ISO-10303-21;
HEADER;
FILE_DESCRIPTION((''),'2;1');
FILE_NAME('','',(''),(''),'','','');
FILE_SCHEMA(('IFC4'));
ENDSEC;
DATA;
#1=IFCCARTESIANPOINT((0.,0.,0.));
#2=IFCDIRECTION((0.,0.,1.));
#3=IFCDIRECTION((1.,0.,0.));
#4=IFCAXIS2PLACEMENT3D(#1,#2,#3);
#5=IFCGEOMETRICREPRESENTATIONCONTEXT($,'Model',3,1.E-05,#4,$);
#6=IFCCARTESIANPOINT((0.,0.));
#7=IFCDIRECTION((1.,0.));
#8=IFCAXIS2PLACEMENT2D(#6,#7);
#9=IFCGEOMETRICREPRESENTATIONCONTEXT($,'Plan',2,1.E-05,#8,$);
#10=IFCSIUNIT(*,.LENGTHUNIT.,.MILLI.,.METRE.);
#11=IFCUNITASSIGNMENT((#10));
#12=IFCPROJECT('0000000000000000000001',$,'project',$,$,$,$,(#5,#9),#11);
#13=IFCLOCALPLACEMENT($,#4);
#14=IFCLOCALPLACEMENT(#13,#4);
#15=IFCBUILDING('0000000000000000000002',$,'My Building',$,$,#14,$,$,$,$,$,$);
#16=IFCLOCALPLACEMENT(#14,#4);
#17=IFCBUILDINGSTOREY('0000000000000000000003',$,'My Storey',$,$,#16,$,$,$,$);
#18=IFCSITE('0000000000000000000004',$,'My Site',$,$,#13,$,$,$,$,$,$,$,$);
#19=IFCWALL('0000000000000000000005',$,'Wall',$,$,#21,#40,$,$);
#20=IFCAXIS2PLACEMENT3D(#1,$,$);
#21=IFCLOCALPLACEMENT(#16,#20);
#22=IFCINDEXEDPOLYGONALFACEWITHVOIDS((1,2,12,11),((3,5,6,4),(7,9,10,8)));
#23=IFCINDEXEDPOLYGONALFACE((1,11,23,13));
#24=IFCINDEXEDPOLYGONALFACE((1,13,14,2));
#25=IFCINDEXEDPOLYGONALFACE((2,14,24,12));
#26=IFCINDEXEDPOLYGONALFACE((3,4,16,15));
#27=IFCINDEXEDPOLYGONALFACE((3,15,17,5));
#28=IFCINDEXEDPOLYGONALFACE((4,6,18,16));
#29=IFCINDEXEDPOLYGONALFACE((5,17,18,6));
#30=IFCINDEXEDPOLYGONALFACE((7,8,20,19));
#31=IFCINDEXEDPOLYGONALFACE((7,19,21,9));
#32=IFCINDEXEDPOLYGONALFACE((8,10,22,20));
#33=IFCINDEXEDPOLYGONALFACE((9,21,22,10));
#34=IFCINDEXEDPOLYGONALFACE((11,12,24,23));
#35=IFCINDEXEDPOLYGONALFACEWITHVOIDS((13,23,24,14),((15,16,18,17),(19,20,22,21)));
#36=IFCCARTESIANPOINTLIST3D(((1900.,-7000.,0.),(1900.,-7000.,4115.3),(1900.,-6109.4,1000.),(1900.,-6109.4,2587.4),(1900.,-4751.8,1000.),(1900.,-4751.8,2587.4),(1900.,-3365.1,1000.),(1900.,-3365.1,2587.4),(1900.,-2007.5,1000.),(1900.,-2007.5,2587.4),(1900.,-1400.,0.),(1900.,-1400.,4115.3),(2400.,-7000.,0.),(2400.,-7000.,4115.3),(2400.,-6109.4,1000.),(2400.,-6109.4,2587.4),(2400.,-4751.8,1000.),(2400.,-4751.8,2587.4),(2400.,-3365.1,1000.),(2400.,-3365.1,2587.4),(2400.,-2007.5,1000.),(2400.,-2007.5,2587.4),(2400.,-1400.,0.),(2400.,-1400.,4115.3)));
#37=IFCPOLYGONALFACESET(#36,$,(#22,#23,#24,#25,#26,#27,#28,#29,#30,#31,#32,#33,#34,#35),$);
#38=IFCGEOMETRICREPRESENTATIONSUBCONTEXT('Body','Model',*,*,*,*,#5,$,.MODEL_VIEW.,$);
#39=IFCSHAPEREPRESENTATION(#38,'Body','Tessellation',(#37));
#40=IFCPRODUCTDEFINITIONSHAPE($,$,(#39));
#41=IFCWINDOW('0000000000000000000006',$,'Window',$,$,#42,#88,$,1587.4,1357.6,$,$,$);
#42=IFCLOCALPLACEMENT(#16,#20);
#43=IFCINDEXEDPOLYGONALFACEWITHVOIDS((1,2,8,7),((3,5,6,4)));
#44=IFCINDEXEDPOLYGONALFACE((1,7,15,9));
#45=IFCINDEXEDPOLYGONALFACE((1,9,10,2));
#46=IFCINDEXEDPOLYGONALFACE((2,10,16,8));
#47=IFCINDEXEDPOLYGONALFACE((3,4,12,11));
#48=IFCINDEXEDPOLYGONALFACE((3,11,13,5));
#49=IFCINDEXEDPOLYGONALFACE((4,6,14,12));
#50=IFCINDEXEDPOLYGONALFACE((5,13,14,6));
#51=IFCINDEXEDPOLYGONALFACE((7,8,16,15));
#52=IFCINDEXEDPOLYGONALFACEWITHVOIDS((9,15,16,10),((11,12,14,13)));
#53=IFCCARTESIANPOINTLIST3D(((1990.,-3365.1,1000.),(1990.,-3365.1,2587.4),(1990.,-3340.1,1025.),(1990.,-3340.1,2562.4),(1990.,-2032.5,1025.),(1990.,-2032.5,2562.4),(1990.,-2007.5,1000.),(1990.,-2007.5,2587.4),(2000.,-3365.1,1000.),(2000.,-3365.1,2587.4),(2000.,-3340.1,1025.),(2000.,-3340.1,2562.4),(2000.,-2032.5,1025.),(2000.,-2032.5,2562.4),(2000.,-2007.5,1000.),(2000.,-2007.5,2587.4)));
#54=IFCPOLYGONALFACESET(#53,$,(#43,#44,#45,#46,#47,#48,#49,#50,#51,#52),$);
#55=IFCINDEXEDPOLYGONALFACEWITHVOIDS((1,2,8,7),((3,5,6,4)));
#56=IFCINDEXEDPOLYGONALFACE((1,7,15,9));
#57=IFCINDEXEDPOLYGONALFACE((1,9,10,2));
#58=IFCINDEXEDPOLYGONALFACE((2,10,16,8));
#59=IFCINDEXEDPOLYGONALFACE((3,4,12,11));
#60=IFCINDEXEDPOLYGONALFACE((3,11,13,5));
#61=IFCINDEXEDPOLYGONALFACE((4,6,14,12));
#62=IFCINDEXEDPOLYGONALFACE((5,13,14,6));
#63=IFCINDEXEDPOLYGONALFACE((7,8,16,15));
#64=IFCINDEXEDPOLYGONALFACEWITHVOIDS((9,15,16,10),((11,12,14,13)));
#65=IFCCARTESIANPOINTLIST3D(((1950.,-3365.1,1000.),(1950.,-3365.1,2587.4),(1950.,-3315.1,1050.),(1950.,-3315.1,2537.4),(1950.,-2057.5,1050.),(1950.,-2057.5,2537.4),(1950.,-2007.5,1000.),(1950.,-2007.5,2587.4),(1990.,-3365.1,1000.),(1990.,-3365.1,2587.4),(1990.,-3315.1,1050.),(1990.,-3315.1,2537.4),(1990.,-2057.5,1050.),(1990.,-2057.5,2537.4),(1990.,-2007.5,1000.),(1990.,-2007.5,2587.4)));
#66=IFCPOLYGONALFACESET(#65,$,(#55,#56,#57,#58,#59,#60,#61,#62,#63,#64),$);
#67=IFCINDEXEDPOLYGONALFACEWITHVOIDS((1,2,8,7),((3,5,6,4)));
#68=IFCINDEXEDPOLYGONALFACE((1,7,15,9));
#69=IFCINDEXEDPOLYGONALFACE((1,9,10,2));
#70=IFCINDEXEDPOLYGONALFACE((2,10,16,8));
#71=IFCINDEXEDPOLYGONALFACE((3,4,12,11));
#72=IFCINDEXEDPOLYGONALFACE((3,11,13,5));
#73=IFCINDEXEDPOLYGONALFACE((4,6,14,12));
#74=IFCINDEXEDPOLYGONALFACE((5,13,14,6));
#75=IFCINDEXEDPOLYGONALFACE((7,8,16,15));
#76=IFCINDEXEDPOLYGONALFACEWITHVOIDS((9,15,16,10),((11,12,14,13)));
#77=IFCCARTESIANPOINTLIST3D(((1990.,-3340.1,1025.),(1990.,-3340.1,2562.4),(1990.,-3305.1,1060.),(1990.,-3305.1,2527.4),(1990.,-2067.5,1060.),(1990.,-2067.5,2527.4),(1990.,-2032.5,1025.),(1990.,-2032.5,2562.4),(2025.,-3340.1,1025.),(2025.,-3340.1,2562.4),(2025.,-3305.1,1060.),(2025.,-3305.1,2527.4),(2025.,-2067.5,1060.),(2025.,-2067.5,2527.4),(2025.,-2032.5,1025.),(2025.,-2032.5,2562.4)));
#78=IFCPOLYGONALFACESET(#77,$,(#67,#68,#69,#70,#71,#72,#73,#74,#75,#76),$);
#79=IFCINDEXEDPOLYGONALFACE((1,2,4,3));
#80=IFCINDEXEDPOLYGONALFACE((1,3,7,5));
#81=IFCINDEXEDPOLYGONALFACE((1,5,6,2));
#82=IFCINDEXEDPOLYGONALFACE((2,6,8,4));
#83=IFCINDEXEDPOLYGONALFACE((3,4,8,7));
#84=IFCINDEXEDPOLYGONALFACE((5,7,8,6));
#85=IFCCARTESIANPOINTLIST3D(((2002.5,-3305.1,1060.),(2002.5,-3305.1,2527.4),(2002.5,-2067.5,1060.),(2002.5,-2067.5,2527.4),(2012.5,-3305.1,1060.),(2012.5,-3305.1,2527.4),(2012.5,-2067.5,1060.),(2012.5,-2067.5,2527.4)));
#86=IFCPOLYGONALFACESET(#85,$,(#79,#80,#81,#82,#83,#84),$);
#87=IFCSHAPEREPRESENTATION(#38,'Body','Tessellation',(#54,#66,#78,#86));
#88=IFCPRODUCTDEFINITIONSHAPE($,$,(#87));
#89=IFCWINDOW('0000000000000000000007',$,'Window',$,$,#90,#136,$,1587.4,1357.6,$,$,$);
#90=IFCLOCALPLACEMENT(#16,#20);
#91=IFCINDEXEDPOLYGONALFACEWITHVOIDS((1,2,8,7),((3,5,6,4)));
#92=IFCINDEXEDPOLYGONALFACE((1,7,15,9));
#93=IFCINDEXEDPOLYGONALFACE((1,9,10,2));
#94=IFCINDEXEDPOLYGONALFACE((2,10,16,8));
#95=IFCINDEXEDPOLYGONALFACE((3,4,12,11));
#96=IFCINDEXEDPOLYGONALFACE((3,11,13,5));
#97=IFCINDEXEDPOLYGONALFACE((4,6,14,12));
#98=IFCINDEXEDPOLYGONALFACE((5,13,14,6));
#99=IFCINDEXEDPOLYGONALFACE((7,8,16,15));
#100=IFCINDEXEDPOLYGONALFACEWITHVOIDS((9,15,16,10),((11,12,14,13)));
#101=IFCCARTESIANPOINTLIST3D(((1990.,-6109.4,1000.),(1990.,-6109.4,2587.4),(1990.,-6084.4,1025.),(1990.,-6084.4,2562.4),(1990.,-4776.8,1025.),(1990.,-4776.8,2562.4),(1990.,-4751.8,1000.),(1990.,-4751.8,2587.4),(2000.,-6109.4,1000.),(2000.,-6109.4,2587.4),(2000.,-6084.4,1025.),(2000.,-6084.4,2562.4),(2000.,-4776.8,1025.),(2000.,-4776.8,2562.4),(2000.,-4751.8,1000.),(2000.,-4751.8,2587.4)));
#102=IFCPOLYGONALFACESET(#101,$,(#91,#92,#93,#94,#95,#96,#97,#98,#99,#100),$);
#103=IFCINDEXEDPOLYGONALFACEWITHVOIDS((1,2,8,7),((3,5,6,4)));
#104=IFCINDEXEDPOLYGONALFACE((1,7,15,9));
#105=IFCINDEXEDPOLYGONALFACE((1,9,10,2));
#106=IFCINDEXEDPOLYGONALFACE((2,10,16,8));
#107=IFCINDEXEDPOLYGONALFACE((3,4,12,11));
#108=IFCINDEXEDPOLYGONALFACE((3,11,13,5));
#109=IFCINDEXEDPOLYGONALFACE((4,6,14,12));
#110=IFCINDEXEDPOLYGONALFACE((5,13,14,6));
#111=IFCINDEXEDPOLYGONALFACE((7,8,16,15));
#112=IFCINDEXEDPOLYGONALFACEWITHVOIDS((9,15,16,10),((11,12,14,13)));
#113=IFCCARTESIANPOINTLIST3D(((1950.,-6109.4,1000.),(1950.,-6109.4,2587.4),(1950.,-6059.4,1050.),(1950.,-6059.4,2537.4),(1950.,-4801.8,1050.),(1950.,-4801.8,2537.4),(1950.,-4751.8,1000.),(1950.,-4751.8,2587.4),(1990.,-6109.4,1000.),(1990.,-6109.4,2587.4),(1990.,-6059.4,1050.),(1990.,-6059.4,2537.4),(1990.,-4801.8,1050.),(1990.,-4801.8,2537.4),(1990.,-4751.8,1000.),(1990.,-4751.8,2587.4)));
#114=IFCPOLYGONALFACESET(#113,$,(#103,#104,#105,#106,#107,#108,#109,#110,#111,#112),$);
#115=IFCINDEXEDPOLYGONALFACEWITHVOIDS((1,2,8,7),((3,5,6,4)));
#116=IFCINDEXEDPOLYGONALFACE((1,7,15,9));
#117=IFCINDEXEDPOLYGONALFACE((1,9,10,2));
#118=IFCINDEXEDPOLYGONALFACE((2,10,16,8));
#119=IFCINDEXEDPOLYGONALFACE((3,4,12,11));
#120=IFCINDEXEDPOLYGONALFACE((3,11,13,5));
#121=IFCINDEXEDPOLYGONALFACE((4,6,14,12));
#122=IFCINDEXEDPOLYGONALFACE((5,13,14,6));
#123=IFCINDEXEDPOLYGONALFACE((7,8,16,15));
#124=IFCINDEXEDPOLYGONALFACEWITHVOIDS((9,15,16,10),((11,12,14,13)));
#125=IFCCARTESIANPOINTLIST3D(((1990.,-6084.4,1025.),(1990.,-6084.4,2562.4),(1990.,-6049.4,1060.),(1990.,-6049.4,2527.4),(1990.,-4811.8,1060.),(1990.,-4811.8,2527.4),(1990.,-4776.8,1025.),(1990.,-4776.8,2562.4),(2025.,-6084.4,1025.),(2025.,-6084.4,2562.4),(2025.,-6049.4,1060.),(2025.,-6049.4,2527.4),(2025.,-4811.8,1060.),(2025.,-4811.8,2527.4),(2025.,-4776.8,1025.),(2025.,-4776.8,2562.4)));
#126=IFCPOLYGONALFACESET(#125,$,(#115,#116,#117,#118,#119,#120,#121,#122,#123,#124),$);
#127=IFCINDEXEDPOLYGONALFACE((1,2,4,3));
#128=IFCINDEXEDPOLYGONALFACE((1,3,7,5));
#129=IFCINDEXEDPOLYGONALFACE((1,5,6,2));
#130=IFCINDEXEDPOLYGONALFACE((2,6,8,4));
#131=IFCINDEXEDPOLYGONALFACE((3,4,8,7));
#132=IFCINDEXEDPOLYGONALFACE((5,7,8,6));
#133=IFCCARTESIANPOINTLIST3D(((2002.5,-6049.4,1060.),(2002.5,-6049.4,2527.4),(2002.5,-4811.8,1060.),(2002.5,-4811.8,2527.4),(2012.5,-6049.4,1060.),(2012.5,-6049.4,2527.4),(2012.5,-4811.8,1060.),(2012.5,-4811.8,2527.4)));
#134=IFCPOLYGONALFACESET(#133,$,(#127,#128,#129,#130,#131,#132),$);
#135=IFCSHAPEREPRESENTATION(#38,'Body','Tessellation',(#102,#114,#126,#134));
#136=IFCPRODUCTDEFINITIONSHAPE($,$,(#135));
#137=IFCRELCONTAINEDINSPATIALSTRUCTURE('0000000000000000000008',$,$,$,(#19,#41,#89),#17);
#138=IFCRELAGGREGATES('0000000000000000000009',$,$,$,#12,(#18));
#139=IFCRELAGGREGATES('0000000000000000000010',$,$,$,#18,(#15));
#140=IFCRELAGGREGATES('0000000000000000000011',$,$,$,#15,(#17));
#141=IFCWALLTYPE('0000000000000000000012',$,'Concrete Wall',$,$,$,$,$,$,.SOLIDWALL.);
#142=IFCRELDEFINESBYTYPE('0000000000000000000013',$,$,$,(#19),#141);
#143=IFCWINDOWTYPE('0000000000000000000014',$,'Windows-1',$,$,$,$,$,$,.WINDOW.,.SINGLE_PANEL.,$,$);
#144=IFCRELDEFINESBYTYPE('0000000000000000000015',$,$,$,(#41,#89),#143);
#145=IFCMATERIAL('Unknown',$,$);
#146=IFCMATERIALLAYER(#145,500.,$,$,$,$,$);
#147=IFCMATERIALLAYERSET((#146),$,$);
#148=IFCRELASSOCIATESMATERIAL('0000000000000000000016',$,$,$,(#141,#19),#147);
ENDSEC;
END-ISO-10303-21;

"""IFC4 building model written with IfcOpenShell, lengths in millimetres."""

from ifc_helpers import new_model, entity, si_unit, frame, origin_with_axes, origin_2d_with_axis, place, context, subcontext, project, spatial, line, indexed_curve, outline, extrude, shape, source, transform, mapped, material, layer, layer_set, layer_usage, type_object, type_shapes, element, fill, save


model = new_model("IFC4")

# Units and contexts
model_context = context("Model", 3, precision=1e-05, world=origin_with_axes())
plan_context = context("Plan", 2, precision=1e-05, world=origin_2d_with_axis())
body_context_1 = subcontext(model_context, "Body", "Model", "MODEL_VIEW")
body_context_2 = subcontext(plan_context, "Body", "Plan", "PLAN_VIEW")
ifc_project = project(units=[si_unit("LENGTHUNIT", "METRE", prefix="MILLI")], contexts=[model_context, plan_context])

# Site, building, storey
site_placement = place(None, origin_with_axes())
site = spatial("IfcSite", under=ifc_project, at=site_placement, Name="My Site")
building_placement = place(site_placement, origin_with_axes())
building = spatial("IfcBuilding", under=site, at=building_placement, Name="My Building")
storey_placement = place(building_placement, origin_with_axes())
storey = spatial("IfcBuildingStorey", under=building, at=storey_placement, Name="My Storey")

# Shared definitions
ifc_material = material(Name="Unknown")

# Wall, openings, windows
ifc_layer_1 = layer(ifc_material, 500.0)
ifc_layer_set_1 = layer_set([ifc_layer_1])
ifc_layer_usage_1 = layer_usage(ifc_layer_set_1, "AXIS2", "POSITIVE", 0.0)
wall_type = type_object("IfcWallType", Name="Concrete Wall", PredefinedType="SOLIDWALL", material=ifc_layer_set_1)
wall_1_placement = place(storey_placement, frame((1900.0, -1400.0, 0.0), z_axis=(0.0, 0.0, 1.0), x_axis=(0.0, -1.0, 0.0)))
wall_1 = element("IfcWall", 1, at=wall_1_placement, inside=storey, type_object=wall_type, material=ifc_layer_usage_1, Name="Wall", context=body_context_1, shape_type="SweptSolid", body=[
    extrude(outline(indexed_curve([(0.0, 0.0), (0.0, 500.0), (5600.0, 500.0), (5600.0, 0.0)], segments=[line(1, 2, 3, 4, 1)])), origin_with_axes(), (0.0, 0.0, 1.0), 4115.3),
])
shared_shape_1 = source(origin_with_axes(), body_context_1, "Body", "SweptSolid", [
    extrude(outline(indexed_curve([(0.0, 0.0), (1357.6, 0.0), (1357.6, 1587.4), (0.0, 1587.4)], segments=[line(1, 2, 3, 4, 1)])), frame((0.0, -600.0, 0.0), z_axis=(0.0, -1.0, 0.0), x_axis=(1.0, 0.0, 0.0)), (0.0, 0.0, -1.0), 1200.0),
])
opening_1_placement = place(wall_1_placement, frame((607.5, 0.0, 1000.0), z_axis=(0.0, 0.0, 1.0), x_axis=(1.0, 0.0, 0.0)))
opening_1 = element("IfcOpeningElement", 2, at=opening_1_placement, cuts=wall_1, PredefinedType="OPENING", context=body_context_1, shape_type="MappedRepresentation", body=[
    mapped(shared_shape_1, transform((0.0, 0.0, 0.0), x_axis=(1.0, 0.0, 0.0), y_axis=(0.0, 1.0, 0.0), z_axis=(0.0, 0.0, 1.0), scale=1.0)),
])
opening_2_placement = place(wall_1_placement, frame((3351.8, 0.0, 1000.0), z_axis=(0.0, 0.0, 1.0), x_axis=(1.0, 0.0, 0.0)))
opening_2 = element("IfcOpeningElement", 3, at=opening_2_placement, cuts=wall_1, PredefinedType="OPENING", context=body_context_1, shape_type="MappedRepresentation", body=[
    mapped(shared_shape_1, transform((0.0, 0.0, 0.0), x_axis=(1.0, 0.0, 0.0), y_axis=(0.0, 1.0, 0.0), z_axis=(0.0, 0.0, 1.0), scale=1.0)),
])
window_type = type_object("IfcWindowType", Name="Windows-1", PartitioningType="SINGLE_PANEL", PredefinedType="WINDOW")
shared_shape_2 = source(origin_with_axes(), body_context_1, "Body", "SweptSolid", [
    extrude(outline(indexed_curve([(0.0, 0.0), (1357.6, 0.0), (1357.6, 1587.4), (0.0, 1587.4)], segments=[line(1, 2, 3, 4, 1)]), holes=[indexed_curve([(25.0, 25.0), (1332.6, 25.0), (1332.6, 1562.4), (25.0, 1562.4)], segments=[line(1, 2, 3, 4, 1)])]), frame((0.0, 90.0, 0.0), z_axis=(0.0, -1.0, 0.0), x_axis=(1.0, 0.0, 0.0)), (0.0, 0.0, -1.0), 10.0),
    extrude(outline(indexed_curve([(0.0, 0.0), (1357.6, 0.0), (1357.6, 1587.4), (0.0, 1587.4)], segments=[line(1, 2, 3, 4, 1)]), holes=[indexed_curve([(50.0, 50.0), (1307.6, 50.0), (1307.6, 1537.4), (50.0, 1537.4)], segments=[line(1, 2, 3, 4, 1)])]), frame((0.0, 50.0, 0.0), z_axis=(0.0, -1.0, 0.0), x_axis=(1.0, 0.0, 0.0)), (0.0, 0.0, -1.0), 40.0),
    extrude(outline(indexed_curve([(0.0, 0.0), (1307.6, 0.0), (1307.6, 1537.4), (0.0, 1537.4)], segments=[line(1, 2, 3, 4, 1)]), holes=[indexed_curve([(35.0, 35.0), (1272.6, 35.0), (1272.6, 1502.4), (35.0, 1502.4)], segments=[line(1, 2, 3, 4, 1)])]), frame((25.0, 90.0, 25.0), z_axis=(0.0, -1.0, 0.0), x_axis=(1.0, 0.0, 0.0)), (0.0, 0.0, -1.0), 35.0),
    extrude(outline(indexed_curve([(35.0, 35.0), (1272.6, 35.0), (1272.6, 1502.4), (35.0, 1502.4)], segments=[line(1, 2, 3, 4, 1)])), frame((25.0, 102.5, 25.0), z_axis=(0.0, -1.0, 0.0), x_axis=(1.0, 0.0, 0.0)), (0.0, 0.0, -1.0), 10.0),
])
shared_shape_3 = source(origin_with_axes(), body_context_2, "Body", "Curve2D", [
    entity("IfcIndexedPolyCurve", entity("IfcCartesianPointList2D", [[50.0, 50.0], [1307.6, 50.0]])),
    entity("IfcIndexedPolyCurve", entity("IfcCartesianPointList2D", [[0.0, 100.0], [25.0, 100.0], [25.0, 90.0], [50.0, 90.0], [50.0, 50.0], [0.0, 50.0]]), [entity("IfcLineIndex", [1, 2, 3, 4, 5, 6, 1])]),
    entity("IfcIndexedPolyCurve", entity("IfcCartesianPointList2D", [[1357.6, 100.0], [1332.6, 100.0], [1332.6, 90.0], [1307.6, 90.0], [1307.6, 50.0], [1357.6, 50.0]]), [entity("IfcLineIndex", [1, 2, 3, 4, 5, 6, 1])]),
    entity("IfcIndexedPolyCurve", entity("IfcCartesianPointList2D", [[25.0, 90.0], [60.0, 90.0], [60.0, 125.0], [25.0, 125.0]]), [entity("IfcLineIndex", [1, 2, 3, 4, 1])]),
    entity("IfcIndexedPolyCurve", entity("IfcCartesianPointList2D", [[1332.6, 90.0], [1297.6, 90.0], [1297.6, 125.0], [1332.6, 125.0]]), [entity("IfcLineIndex", [1, 2, 3, 4, 1])]),
    entity("IfcIndexedPolyCurve", entity("IfcCartesianPointList2D", [[60.0, 90.0], [1297.6, 90.0]])),
    entity("IfcIndexedPolyCurve", entity("IfcCartesianPointList2D", [[60.0, 125.0], [1297.6, 125.0]])),
    entity("IfcIndexedPolyCurve", entity("IfcCartesianPointList2D", [[60.0, 107.5], [1297.6, 107.5]])),
])
type_shapes(window_type, [shared_shape_2, shared_shape_3])
window_1_placement = place(opening_1_placement, frame((0.0, 0.0, 0.0), z_axis=(0.0, 0.0, 1.0), x_axis=(1.0, 0.0, 0.0)))
window_1 = element("IfcWindow", 4, at=window_1_placement, inside=storey, type_object=window_type, Name="Window", OverallHeight=1587.4, OverallWidth=1357.6, shapes=[
    shape(body_context_1, "Body", "MappedRepresentation", [mapped(shared_shape_2, transform((0.0, 0.0, 0.0), x_axis=(1.0, 0.0, 0.0), y_axis=(0.0, 1.0, 0.0), z_axis=(0.0, 0.0, 1.0), scale=1.0))]),
    shape(body_context_2, "Body", "MappedRepresentation", [mapped(shared_shape_3, transform((0.0, 0.0, 0.0), x_axis=(1.0, 0.0, 0.0), y_axis=(0.0, 1.0, 0.0), z_axis=(0.0, 0.0, 1.0), scale=1.0))]),
])
fill(opening_1, window_1)
window_2_placement = place(opening_2_placement, frame((0.0, 0.0, 0.0), z_axis=(0.0, 0.0, 1.0), x_axis=(1.0, 0.0, 0.0)))
window_2 = element("IfcWindow", 5, at=window_2_placement, inside=storey, type_object=window_type, Name="Window", OverallHeight=1587.4, OverallWidth=1357.6, shapes=[
    shape(body_context_1, "Body", "MappedRepresentation", [mapped(shared_shape_2, transform((0.0, 0.0, 0.0), x_axis=(1.0, 0.0, 0.0), y_axis=(0.0, 1.0, 0.0), z_axis=(0.0, 0.0, 1.0), scale=1.0))]),
    shape(body_context_2, "Body", "MappedRepresentation", [mapped(shared_shape_3, transform((0.0, 0.0, 0.0), x_axis=(1.0, 0.0, 0.0), y_axis=(0.0, 1.0, 0.0), z_axis=(0.0, 0.0, 1.0), scale=1.0))]),
])
fill(opening_2, window_2)

save(model, "model.ifc")
